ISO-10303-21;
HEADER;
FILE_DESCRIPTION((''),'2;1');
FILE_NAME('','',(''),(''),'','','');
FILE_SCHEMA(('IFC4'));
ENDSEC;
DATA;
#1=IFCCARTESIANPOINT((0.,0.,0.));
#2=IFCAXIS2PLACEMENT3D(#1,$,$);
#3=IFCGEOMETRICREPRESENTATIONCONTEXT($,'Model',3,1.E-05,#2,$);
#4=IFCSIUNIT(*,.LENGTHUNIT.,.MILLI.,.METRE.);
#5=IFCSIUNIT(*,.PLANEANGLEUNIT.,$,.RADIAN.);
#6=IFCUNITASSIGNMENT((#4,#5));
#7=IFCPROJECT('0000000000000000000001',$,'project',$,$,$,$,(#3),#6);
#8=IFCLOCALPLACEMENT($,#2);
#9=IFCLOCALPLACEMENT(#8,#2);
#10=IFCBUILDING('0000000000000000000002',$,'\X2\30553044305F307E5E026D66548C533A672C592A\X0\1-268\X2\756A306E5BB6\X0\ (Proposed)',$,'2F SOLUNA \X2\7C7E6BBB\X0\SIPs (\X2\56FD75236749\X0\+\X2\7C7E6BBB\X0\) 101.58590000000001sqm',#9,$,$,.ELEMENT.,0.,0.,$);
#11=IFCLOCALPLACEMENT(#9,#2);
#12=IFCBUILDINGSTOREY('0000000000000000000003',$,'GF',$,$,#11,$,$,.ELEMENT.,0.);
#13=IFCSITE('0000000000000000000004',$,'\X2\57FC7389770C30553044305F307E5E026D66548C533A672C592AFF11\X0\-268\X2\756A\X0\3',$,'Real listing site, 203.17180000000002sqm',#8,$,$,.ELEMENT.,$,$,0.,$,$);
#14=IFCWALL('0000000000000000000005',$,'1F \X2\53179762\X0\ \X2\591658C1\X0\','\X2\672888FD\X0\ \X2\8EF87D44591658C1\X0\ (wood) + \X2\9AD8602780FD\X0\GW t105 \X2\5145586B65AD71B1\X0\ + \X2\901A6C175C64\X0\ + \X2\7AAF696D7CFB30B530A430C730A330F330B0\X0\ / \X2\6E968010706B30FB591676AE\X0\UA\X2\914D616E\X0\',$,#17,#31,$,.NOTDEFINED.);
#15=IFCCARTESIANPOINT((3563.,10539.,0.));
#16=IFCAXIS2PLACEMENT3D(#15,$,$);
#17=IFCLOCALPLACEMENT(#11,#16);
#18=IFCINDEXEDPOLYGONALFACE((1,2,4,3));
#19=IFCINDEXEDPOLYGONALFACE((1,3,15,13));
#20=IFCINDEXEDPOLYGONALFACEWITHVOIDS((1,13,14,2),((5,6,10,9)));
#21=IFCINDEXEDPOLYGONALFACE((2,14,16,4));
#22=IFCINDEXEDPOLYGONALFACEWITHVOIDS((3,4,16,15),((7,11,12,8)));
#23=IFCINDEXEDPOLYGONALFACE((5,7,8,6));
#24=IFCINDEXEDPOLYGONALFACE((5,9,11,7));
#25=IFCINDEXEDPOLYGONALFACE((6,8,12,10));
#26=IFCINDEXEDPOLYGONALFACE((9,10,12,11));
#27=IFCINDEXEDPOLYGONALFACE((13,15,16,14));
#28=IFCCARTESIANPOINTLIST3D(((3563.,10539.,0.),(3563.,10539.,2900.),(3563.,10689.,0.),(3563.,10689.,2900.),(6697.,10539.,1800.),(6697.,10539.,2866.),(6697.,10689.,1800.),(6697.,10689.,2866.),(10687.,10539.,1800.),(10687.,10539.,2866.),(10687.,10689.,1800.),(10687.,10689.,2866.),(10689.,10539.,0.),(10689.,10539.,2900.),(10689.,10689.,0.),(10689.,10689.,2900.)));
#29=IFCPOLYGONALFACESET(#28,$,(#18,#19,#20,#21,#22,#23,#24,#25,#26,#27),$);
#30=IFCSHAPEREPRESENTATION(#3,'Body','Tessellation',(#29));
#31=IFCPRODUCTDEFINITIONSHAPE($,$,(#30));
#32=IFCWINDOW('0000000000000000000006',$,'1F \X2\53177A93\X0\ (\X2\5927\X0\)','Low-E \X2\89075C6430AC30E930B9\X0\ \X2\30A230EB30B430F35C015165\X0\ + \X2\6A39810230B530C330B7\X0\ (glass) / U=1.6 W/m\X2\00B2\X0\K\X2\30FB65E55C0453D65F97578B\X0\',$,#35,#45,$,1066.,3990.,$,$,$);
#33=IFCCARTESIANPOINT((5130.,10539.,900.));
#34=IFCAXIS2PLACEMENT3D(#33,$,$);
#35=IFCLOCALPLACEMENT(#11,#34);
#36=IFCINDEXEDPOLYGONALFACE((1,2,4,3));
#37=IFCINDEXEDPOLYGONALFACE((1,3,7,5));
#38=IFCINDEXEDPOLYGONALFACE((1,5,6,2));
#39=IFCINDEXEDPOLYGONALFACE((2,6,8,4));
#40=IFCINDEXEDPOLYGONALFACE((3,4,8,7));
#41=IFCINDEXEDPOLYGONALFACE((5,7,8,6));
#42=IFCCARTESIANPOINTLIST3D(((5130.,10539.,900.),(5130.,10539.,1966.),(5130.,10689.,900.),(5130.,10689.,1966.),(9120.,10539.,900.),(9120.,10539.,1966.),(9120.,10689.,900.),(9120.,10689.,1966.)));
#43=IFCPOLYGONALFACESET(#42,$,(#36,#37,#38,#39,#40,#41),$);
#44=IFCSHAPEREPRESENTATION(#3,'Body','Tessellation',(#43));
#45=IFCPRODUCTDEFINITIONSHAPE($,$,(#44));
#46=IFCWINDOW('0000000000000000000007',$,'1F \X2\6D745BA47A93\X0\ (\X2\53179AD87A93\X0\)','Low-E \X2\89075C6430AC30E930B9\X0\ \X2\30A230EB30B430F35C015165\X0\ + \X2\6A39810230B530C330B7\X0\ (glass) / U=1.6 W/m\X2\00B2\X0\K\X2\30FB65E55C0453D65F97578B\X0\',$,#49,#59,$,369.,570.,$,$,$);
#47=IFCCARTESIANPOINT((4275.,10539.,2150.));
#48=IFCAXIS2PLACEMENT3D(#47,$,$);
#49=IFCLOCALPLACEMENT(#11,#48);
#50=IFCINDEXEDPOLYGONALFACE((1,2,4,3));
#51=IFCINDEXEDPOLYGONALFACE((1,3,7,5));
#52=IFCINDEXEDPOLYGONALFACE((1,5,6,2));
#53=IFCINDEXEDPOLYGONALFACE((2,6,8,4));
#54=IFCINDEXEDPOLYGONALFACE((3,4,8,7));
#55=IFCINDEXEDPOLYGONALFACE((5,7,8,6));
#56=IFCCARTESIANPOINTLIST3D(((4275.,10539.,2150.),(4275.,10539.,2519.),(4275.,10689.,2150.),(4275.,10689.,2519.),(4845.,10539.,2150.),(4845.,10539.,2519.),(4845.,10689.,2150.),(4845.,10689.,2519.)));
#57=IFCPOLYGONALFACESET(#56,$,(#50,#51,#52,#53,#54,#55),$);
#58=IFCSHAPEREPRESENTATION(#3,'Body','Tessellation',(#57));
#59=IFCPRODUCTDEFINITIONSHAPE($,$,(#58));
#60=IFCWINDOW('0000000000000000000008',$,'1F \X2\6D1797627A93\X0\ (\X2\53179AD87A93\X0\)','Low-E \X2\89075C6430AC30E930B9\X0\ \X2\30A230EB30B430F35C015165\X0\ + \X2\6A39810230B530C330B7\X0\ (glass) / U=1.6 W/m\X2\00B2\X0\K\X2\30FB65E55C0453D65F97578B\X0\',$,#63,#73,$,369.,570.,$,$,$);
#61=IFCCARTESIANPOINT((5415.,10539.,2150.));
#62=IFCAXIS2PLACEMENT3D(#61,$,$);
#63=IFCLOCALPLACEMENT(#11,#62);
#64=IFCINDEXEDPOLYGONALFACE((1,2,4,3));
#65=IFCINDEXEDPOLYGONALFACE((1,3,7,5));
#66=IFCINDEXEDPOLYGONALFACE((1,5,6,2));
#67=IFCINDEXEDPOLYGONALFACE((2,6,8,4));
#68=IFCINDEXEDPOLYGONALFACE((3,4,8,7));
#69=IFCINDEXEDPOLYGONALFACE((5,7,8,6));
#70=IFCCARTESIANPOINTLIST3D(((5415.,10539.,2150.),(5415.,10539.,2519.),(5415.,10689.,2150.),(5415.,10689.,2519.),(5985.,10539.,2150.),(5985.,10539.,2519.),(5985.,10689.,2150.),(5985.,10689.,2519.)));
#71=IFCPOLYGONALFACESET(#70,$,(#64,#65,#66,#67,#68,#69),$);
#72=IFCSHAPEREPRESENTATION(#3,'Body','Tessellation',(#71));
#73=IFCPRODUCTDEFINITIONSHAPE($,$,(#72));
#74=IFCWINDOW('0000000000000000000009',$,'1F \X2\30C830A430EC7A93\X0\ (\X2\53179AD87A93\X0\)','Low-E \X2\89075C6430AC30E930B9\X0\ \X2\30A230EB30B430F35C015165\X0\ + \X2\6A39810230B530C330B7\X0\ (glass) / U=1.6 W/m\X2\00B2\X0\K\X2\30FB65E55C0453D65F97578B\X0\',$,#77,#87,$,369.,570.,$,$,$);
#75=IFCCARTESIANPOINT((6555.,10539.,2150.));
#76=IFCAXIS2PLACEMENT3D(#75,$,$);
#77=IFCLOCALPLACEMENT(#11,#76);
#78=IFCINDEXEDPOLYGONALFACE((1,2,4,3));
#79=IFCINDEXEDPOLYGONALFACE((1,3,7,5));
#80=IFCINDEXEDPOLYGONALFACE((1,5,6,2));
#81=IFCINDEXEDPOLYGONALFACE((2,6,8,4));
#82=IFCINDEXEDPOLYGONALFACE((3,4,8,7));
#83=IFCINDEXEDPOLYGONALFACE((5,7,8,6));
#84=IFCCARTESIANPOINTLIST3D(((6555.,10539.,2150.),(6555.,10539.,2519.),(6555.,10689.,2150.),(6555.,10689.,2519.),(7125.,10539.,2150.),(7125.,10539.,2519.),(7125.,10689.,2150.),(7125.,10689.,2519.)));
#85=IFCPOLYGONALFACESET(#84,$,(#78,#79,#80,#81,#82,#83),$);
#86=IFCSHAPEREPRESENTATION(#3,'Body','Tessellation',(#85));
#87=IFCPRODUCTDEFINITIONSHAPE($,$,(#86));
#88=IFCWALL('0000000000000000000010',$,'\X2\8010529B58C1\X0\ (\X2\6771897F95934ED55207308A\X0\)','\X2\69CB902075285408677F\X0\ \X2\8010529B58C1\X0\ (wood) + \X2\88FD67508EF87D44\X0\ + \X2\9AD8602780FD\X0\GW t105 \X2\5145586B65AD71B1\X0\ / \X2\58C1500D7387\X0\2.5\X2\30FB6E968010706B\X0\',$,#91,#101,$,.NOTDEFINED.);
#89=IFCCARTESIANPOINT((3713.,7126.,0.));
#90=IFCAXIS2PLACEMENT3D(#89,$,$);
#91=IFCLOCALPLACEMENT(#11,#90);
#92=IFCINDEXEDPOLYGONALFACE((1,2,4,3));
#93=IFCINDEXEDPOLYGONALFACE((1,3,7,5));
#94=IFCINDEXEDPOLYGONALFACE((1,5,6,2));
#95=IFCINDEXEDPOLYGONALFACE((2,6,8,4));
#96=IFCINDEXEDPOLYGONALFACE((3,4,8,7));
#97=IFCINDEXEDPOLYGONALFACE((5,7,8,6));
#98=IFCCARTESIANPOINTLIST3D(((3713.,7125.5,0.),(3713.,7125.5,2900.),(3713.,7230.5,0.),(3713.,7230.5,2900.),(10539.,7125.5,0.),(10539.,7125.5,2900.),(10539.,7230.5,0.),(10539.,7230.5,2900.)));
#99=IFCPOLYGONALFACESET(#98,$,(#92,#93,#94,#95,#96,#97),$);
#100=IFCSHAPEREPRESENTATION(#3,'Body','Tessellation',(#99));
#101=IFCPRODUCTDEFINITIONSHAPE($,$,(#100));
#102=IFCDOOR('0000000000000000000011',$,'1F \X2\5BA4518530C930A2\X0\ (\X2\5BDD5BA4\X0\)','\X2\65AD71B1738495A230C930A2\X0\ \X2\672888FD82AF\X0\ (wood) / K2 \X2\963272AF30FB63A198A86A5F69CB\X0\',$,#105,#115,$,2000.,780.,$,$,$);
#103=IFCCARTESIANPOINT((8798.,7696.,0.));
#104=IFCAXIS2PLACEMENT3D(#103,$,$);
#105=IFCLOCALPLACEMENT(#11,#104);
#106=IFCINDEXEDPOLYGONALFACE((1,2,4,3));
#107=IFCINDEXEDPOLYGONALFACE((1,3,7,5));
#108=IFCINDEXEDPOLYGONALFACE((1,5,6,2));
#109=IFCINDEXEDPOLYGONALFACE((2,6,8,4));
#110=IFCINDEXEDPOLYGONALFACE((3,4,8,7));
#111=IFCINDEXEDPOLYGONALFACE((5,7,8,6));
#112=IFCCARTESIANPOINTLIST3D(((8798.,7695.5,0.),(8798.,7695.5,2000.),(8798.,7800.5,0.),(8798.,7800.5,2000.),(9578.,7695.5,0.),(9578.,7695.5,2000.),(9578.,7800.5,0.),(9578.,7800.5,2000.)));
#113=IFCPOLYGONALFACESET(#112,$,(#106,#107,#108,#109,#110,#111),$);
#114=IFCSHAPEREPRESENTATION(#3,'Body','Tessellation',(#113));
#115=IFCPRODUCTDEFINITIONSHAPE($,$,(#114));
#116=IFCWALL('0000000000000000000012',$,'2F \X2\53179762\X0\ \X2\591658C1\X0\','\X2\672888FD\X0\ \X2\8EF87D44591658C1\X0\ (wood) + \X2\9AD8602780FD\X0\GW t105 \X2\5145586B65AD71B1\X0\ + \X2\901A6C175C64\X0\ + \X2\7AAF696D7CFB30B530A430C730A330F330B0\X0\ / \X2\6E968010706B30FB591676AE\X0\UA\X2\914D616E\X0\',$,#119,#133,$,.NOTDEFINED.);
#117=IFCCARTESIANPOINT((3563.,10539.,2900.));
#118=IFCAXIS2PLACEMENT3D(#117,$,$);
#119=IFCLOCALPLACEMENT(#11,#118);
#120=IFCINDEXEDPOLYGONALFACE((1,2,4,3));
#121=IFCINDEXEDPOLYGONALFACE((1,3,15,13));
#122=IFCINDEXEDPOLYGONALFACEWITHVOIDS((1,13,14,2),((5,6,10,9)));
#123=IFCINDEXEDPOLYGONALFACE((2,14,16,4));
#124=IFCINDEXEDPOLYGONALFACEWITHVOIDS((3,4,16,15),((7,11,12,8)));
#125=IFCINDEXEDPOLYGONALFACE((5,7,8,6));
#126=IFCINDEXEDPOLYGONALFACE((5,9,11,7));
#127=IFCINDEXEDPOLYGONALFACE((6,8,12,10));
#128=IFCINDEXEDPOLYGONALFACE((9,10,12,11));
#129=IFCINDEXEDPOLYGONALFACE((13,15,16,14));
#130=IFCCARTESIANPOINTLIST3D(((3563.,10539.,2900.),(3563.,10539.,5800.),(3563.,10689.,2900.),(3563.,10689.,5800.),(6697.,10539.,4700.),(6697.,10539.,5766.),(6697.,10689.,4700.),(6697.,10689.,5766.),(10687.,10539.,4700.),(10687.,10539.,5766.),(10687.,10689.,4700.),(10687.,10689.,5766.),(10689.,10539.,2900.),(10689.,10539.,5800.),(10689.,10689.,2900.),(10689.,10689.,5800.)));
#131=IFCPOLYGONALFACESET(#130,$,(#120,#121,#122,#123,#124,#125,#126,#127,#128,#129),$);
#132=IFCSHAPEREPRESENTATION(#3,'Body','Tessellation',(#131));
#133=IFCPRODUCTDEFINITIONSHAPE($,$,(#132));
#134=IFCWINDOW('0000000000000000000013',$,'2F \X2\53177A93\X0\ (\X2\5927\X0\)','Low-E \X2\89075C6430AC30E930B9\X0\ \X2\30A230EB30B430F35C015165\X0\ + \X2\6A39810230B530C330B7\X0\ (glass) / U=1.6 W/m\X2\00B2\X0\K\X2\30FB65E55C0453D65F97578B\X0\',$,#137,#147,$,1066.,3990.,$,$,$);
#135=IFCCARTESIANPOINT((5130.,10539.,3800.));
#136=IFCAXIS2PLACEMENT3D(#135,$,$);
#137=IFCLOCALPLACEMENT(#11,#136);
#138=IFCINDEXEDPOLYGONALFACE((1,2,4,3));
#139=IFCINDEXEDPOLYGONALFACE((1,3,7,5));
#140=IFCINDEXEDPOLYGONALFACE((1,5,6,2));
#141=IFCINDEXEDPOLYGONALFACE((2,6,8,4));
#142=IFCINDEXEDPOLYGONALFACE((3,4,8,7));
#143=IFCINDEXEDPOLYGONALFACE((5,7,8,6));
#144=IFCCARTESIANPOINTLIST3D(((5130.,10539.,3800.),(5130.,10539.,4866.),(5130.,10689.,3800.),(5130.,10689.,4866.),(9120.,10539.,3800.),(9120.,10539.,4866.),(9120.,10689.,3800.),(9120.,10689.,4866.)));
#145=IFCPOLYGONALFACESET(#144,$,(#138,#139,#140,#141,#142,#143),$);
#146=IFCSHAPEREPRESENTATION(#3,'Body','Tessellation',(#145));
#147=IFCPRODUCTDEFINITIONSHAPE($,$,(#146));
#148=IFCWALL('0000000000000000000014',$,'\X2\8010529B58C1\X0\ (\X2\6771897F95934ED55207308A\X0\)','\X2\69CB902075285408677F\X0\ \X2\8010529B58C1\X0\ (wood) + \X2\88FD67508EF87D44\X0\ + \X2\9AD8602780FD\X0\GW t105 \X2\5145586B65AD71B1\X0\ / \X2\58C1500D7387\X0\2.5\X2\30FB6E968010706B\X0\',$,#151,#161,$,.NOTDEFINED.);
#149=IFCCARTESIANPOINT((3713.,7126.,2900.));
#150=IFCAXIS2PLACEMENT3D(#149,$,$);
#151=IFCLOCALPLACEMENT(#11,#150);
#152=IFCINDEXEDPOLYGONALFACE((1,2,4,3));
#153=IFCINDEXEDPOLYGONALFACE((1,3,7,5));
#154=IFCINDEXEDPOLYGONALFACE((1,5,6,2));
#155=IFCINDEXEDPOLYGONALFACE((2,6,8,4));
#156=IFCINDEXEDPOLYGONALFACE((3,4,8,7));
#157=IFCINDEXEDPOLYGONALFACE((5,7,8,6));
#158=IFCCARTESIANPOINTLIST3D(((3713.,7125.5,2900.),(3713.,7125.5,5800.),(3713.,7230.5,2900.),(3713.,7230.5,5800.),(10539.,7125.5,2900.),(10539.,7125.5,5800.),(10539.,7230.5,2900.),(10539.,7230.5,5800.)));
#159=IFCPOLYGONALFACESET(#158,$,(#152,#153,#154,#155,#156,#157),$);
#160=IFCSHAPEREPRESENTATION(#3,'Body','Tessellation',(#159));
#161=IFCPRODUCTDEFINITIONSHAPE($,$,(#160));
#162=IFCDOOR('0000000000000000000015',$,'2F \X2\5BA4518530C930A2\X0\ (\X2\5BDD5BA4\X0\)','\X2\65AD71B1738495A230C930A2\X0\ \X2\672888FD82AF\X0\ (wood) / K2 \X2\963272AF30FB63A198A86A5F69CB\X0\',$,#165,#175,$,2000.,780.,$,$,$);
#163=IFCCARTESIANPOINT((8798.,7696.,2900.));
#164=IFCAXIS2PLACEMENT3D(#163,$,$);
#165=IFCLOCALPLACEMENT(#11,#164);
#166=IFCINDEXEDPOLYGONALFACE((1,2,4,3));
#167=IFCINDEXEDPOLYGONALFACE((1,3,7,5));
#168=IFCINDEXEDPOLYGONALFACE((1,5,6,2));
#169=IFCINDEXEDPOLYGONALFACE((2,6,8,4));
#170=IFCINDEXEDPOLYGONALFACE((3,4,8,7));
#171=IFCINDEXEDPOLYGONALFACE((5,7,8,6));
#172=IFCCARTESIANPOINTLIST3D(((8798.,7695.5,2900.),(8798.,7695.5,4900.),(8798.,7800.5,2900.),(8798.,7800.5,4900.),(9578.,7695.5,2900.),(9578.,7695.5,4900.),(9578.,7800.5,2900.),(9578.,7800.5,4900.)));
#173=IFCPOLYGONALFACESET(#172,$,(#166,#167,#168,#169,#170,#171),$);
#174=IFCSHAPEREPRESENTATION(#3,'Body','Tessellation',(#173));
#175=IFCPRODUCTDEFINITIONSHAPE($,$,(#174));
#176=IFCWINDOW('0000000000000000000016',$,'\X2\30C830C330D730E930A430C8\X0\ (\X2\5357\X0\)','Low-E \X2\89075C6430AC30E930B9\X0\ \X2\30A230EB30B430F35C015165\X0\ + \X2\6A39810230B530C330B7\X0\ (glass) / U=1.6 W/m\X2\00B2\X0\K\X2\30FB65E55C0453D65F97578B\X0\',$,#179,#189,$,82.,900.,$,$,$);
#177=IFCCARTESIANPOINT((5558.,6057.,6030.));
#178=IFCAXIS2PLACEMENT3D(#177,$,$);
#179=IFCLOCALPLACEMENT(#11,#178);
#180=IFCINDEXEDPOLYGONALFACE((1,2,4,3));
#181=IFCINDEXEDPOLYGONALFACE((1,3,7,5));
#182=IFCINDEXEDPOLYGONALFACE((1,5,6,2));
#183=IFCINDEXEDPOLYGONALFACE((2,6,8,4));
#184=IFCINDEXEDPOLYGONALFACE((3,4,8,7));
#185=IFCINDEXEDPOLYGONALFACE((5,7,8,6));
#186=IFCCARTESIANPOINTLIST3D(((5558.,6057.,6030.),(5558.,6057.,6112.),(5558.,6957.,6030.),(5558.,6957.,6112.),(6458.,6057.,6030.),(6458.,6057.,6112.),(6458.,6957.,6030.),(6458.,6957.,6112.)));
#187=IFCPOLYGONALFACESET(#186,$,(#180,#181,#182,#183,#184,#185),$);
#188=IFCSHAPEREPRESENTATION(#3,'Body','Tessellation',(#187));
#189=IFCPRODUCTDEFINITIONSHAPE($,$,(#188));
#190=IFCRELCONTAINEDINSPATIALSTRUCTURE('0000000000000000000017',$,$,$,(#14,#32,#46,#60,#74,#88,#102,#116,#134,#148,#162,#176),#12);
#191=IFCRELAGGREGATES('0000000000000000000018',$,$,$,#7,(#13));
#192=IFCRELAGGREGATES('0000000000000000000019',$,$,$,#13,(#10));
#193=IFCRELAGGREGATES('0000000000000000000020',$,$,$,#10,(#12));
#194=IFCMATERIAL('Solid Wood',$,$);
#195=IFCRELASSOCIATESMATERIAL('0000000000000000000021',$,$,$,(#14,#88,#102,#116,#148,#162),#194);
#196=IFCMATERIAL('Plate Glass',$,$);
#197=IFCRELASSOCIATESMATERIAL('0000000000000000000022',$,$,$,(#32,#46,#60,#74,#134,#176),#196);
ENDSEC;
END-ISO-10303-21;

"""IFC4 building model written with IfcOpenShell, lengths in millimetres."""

from ifc_helpers import new_model, si_unit, frame, frame_2d, origin, place, context, project, spatial, rectangle, extrude, material, element, fill, save


model = new_model("IFC4")

# Units and contexts
model_context = context("Model", 3, precision=1e-05, world=origin())
ifc_project = project(units=[si_unit("LENGTHUNIT", "METRE", prefix="MILLI"), si_unit("PLANEANGLEUNIT", "RADIAN")], contexts=[model_context])

# Site, building, storey
site_placement = place(None, origin())
site = spatial("IfcSite", under=ifc_project, at=site_placement, Name="埼玉県さいたま市浦和区本太１-268番3", ObjectType="Real listing site, 203.17180000000002sqm", CompositionType="ELEMENT", RefElevation=0.0)
building_placement = place(site_placement, origin())
building = spatial("IfcBuilding", under=site, at=building_placement, Name="さいたま市浦和区本太1-268番の家 (Proposed)", ObjectType="2F SOLUNA 籾殻SIPs (国産杉+籾殻) 101.58590000000001sqm", CompositionType="ELEMENT", ElevationOfRefHeight=0.0, ElevationOfTerrain=0.0)
storey_placement = place(building_placement, origin())
storey = spatial("IfcBuildingStorey", under=building, at=storey_placement, Name="GF", CompositionType="ELEMENT", Elevation=0.0)

# Wall, openings, windows
ifc_material_1 = material(Name="Solid Wood")
wall_1_placement = place(storey_placement, frame((3563.0, 10539.0, 0.0)))
wall_1 = element("IfcWall", 1, at=wall_1_placement, inside=storey, material=ifc_material_1, Name="1F 北面 外壁", Description="木製 軸組外壁 (wood) + 高性能GW t105 充填断熱 + 通気層 + 窯業系サイディング / 準耐火・外皮UA配慮", PredefinedType="NOTDEFINED", context=model_context, shape_type="SweptSolid", body=[
    extrude(rectangle(XDim=7126.0, YDim=150.0, at=frame_2d((3563.0, 75.0))), frame((3563.0, 10539.0, 0.0)), (0.0, 0.0, 1.0), 2900.0),
])
opening_1_placement = place(storey_placement, frame((5130.0, 10539.0, 900.0)))
opening_1 = element("IfcOpeningElement", 2, at=opening_1_placement, cuts=wall_1, PredefinedType="NOTDEFINED", context=model_context, shape_type="SweptSolid", body=[
    extrude(rectangle(XDim=3990.0, YDim=150.0, at=frame_2d((1995.0, 75.0))), frame((5130.0, 10539.0, 900.0)), (0.0, 0.0, 1.0), 1066.0),
])
opening_2_placement = place(storey_placement, frame((4275.0, 10539.0, 2150.0)))
opening_2 = element("IfcOpeningElement", 3, at=opening_2_placement, cuts=wall_1, PredefinedType="NOTDEFINED", context=model_context, shape_type="SweptSolid", body=[
    extrude(rectangle(XDim=570.0, YDim=150.0, at=frame_2d((285.0, 75.0))), frame((4275.0, 10539.0, 2150.0)), (0.0, 0.0, 1.0), 369.0),
])
opening_3_placement = place(storey_placement, frame((5415.0, 10539.0, 2150.0)))
opening_3 = element("IfcOpeningElement", 4, at=opening_3_placement, cuts=wall_1, PredefinedType="NOTDEFINED", context=model_context, shape_type="SweptSolid", body=[
    extrude(rectangle(XDim=570.0, YDim=150.0, at=frame_2d((285.0, 75.0))), frame((5415.0, 10539.0, 2150.0)), (0.0, 0.0, 1.0), 369.0),
])
opening_4_placement = place(storey_placement, frame((6555.0, 10539.0, 2150.0)))
opening_4 = element("IfcOpeningElement", 5, at=opening_4_placement, cuts=wall_1, PredefinedType="NOTDEFINED", context=model_context, shape_type="SweptSolid", body=[
    extrude(rectangle(XDim=570.0, YDim=150.0, at=frame_2d((285.0, 75.0))), frame((6555.0, 10539.0, 2150.0)), (0.0, 0.0, 1.0), 369.0),
])
ifc_material_2 = material(Name="Plate Glass")
window_1_placement = place(storey_placement, frame((5130.0, 10539.0, 900.0)))
window_1 = element("IfcWindow", 6, at=window_1_placement, inside=storey, material=ifc_material_2, Name="1F 北窓 (大)", Description="Low-E 複層ガラス アルゴン封入 + 樹脂サッシ (glass) / U=1.6 W/m²K・日射取得型", OverallHeight=1066.0, OverallWidth=3990.0, context=model_context, shape_type="SweptSolid", body=[
    extrude(rectangle(XDim=3990.0, YDim=150.0, at=frame_2d((1995.0, 75.0))), frame((5130.0, 10539.0, 900.0)), (0.0, 0.0, 1.0), 1066.0),
])
fill(opening_1, window_1)
window_2_placement = place(storey_placement, frame((4275.0, 10539.0, 2150.0)))
window_2 = element("IfcWindow", 7, at=window_2_placement, inside=storey, material=ifc_material_2, Name="1F 浴室窓 (北高窓)", Description="Low-E 複層ガラス アルゴン封入 + 樹脂サッシ (glass) / U=1.6 W/m²K・日射取得型", OverallHeight=369.0, OverallWidth=570.0, context=model_context, shape_type="SweptSolid", body=[
    extrude(rectangle(XDim=570.0, YDim=150.0, at=frame_2d((285.0, 75.0))), frame((4275.0, 10539.0, 2150.0)), (0.0, 0.0, 1.0), 369.0),
])
fill(opening_2, window_2)
window_3_placement = place(storey_placement, frame((5415.0, 10539.0, 2150.0)))
window_3 = element("IfcWindow", 8, at=window_3_placement, inside=storey, material=ifc_material_2, Name="1F 洗面窓 (北高窓)", Description="Low-E 複層ガラス アルゴン封入 + 樹脂サッシ (glass) / U=1.6 W/m²K・日射取得型", OverallHeight=369.0, OverallWidth=570.0, context=model_context, shape_type="SweptSolid", body=[
    extrude(rectangle(XDim=570.0, YDim=150.0, at=frame_2d((285.0, 75.0))), frame((5415.0, 10539.0, 2150.0)), (0.0, 0.0, 1.0), 369.0),
])
fill(opening_3, window_3)
window_4_placement = place(storey_placement, frame((6555.0, 10539.0, 2150.0)))
window_4 = element("IfcWindow", 9, at=window_4_placement, inside=storey, material=ifc_material_2, Name="1F トイレ窓 (北高窓)", Description="Low-E 複層ガラス アルゴン封入 + 樹脂サッシ (glass) / U=1.6 W/m²K・日射取得型", OverallHeight=369.0, OverallWidth=570.0, context=model_context, shape_type="SweptSolid", body=[
    extrude(rectangle(XDim=570.0, YDim=150.0, at=frame_2d((285.0, 75.0))), frame((6555.0, 10539.0, 2150.0)), (0.0, 0.0, 1.0), 369.0),
])
fill(opening_4, window_4)

# Wall
wall_2_placement = place(storey_placement, frame((3713.0, 7126.0, 0.0)))
element("IfcWall", 10, at=wall_2_placement, inside=storey, material=ifc_material_1, Name="耐力壁 (東西間仕切り)", Description="構造用合板 耐力壁 (wood) + 製材軸組 + 高性能GW t105 充填断熱 / 壁倍率2.5・準耐火", PredefinedType="NOTDEFINED", context=model_context, shape_type="SweptSolid", body=[
    extrude(rectangle(XDim=6826.0, YDim=105.0, at=frame_2d((3413.0, 52.0))), frame((3713.0, 7126.0, 0.0)), (0.0, 0.0, 1.0), 2900.0),
])

# Door
door_1_placement = place(storey_placement, frame((8798.0, 7696.0, 0.0)))
element("IfcDoor", 11, at=door_1_placement, inside=storey, material=ifc_material_1, Name="1F 室内ドア (寝室)", Description="断熱玄関ドア 木製芯 (wood) / K2 防犯・採風機構", OverallHeight=2000.0, OverallWidth=780.0, context=model_context, shape_type="SweptSolid", body=[
    extrude(rectangle(XDim=780.0, YDim=105.0, at=frame_2d((390.0, 52.0))), frame((8798.0, 7696.0, 0.0)), (0.0, 0.0, 1.0), 2000.0),
])

# Wall, opening, window
wall_3_placement = place(storey_placement, frame((3563.0, 10539.0, 2900.0)))
wall_3 = element("IfcWall", 12, at=wall_3_placement, inside=storey, material=ifc_material_1, Name="2F 北面 外壁", Description="木製 軸組外壁 (wood) + 高性能GW t105 充填断熱 + 通気層 + 窯業系サイディング / 準耐火・外皮UA配慮", PredefinedType="NOTDEFINED", context=model_context, shape_type="SweptSolid", body=[
    extrude(rectangle(XDim=7126.0, YDim=150.0, at=frame_2d((3563.0, 75.0))), frame((3563.0, 10539.0, 2900.0)), (0.0, 0.0, 1.0), 2900.0),
])
opening_5_placement = place(storey_placement, frame((5130.0, 10539.0, 3800.0)))
opening_5 = element("IfcOpeningElement", 13, at=opening_5_placement, cuts=wall_3, PredefinedType="NOTDEFINED", context=model_context, shape_type="SweptSolid", body=[
    extrude(rectangle(XDim=3990.0, YDim=150.0, at=frame_2d((1995.0, 75.0))), frame((5130.0, 10539.0, 3800.0)), (0.0, 0.0, 1.0), 1066.0),
])
window_5_placement = place(storey_placement, frame((5130.0, 10539.0, 3800.0)))
window_5 = element("IfcWindow", 14, at=window_5_placement, inside=storey, material=ifc_material_2, Name="2F 北窓 (大)", Description="Low-E 複層ガラス アルゴン封入 + 樹脂サッシ (glass) / U=1.6 W/m²K・日射取得型", OverallHeight=1066.0, OverallWidth=3990.0, context=model_context, shape_type="SweptSolid", body=[
    extrude(rectangle(XDim=3990.0, YDim=150.0, at=frame_2d((1995.0, 75.0))), frame((5130.0, 10539.0, 3800.0)), (0.0, 0.0, 1.0), 1066.0),
])
fill(opening_5, window_5)

# Wall
wall_4_placement = place(storey_placement, frame((3713.0, 7126.0, 2900.0)))
element("IfcWall", 15, at=wall_4_placement, inside=storey, material=ifc_material_1, Name="耐力壁 (東西間仕切り)", Description="構造用合板 耐力壁 (wood) + 製材軸組 + 高性能GW t105 充填断熱 / 壁倍率2.5・準耐火", PredefinedType="NOTDEFINED", context=model_context, shape_type="SweptSolid", body=[
    extrude(rectangle(XDim=6826.0, YDim=105.0, at=frame_2d((3413.0, 52.0))), frame((3713.0, 7126.0, 2900.0)), (0.0, 0.0, 1.0), 2900.0),
])

# Door
door_2_placement = place(storey_placement, frame((8798.0, 7696.0, 2900.0)))
element("IfcDoor", 16, at=door_2_placement, inside=storey, material=ifc_material_1, Name="2F 室内ドア (寝室)", Description="断熱玄関ドア 木製芯 (wood) / K2 防犯・採風機構", OverallHeight=2000.0, OverallWidth=780.0, context=model_context, shape_type="SweptSolid", body=[
    extrude(rectangle(XDim=780.0, YDim=105.0, at=frame_2d((390.0, 52.0))), frame((8798.0, 7696.0, 2900.0)), (0.0, 0.0, 1.0), 2000.0),
])

# Window
window_6_placement = place(storey_placement, frame((5558.0, 6057.0, 6030.0)))
element("IfcWindow", 17, at=window_6_placement, inside=storey, material=ifc_material_2, Name="トップライト (南)", Description="Low-E 複層ガラス アルゴン封入 + 樹脂サッシ (glass) / U=1.6 W/m²K・日射取得型", OverallHeight=82.0, OverallWidth=900.0, context=model_context, shape_type="SweptSolid", body=[
    extrude(rectangle(XDim=900.0, YDim=900.0, at=frame_2d((450.0, 450.0))), frame((5558.0, 6057.0, 6030.0)), (0.0, 0.0, 1.0), 82.0),
])

save(model, "model.ifc")
